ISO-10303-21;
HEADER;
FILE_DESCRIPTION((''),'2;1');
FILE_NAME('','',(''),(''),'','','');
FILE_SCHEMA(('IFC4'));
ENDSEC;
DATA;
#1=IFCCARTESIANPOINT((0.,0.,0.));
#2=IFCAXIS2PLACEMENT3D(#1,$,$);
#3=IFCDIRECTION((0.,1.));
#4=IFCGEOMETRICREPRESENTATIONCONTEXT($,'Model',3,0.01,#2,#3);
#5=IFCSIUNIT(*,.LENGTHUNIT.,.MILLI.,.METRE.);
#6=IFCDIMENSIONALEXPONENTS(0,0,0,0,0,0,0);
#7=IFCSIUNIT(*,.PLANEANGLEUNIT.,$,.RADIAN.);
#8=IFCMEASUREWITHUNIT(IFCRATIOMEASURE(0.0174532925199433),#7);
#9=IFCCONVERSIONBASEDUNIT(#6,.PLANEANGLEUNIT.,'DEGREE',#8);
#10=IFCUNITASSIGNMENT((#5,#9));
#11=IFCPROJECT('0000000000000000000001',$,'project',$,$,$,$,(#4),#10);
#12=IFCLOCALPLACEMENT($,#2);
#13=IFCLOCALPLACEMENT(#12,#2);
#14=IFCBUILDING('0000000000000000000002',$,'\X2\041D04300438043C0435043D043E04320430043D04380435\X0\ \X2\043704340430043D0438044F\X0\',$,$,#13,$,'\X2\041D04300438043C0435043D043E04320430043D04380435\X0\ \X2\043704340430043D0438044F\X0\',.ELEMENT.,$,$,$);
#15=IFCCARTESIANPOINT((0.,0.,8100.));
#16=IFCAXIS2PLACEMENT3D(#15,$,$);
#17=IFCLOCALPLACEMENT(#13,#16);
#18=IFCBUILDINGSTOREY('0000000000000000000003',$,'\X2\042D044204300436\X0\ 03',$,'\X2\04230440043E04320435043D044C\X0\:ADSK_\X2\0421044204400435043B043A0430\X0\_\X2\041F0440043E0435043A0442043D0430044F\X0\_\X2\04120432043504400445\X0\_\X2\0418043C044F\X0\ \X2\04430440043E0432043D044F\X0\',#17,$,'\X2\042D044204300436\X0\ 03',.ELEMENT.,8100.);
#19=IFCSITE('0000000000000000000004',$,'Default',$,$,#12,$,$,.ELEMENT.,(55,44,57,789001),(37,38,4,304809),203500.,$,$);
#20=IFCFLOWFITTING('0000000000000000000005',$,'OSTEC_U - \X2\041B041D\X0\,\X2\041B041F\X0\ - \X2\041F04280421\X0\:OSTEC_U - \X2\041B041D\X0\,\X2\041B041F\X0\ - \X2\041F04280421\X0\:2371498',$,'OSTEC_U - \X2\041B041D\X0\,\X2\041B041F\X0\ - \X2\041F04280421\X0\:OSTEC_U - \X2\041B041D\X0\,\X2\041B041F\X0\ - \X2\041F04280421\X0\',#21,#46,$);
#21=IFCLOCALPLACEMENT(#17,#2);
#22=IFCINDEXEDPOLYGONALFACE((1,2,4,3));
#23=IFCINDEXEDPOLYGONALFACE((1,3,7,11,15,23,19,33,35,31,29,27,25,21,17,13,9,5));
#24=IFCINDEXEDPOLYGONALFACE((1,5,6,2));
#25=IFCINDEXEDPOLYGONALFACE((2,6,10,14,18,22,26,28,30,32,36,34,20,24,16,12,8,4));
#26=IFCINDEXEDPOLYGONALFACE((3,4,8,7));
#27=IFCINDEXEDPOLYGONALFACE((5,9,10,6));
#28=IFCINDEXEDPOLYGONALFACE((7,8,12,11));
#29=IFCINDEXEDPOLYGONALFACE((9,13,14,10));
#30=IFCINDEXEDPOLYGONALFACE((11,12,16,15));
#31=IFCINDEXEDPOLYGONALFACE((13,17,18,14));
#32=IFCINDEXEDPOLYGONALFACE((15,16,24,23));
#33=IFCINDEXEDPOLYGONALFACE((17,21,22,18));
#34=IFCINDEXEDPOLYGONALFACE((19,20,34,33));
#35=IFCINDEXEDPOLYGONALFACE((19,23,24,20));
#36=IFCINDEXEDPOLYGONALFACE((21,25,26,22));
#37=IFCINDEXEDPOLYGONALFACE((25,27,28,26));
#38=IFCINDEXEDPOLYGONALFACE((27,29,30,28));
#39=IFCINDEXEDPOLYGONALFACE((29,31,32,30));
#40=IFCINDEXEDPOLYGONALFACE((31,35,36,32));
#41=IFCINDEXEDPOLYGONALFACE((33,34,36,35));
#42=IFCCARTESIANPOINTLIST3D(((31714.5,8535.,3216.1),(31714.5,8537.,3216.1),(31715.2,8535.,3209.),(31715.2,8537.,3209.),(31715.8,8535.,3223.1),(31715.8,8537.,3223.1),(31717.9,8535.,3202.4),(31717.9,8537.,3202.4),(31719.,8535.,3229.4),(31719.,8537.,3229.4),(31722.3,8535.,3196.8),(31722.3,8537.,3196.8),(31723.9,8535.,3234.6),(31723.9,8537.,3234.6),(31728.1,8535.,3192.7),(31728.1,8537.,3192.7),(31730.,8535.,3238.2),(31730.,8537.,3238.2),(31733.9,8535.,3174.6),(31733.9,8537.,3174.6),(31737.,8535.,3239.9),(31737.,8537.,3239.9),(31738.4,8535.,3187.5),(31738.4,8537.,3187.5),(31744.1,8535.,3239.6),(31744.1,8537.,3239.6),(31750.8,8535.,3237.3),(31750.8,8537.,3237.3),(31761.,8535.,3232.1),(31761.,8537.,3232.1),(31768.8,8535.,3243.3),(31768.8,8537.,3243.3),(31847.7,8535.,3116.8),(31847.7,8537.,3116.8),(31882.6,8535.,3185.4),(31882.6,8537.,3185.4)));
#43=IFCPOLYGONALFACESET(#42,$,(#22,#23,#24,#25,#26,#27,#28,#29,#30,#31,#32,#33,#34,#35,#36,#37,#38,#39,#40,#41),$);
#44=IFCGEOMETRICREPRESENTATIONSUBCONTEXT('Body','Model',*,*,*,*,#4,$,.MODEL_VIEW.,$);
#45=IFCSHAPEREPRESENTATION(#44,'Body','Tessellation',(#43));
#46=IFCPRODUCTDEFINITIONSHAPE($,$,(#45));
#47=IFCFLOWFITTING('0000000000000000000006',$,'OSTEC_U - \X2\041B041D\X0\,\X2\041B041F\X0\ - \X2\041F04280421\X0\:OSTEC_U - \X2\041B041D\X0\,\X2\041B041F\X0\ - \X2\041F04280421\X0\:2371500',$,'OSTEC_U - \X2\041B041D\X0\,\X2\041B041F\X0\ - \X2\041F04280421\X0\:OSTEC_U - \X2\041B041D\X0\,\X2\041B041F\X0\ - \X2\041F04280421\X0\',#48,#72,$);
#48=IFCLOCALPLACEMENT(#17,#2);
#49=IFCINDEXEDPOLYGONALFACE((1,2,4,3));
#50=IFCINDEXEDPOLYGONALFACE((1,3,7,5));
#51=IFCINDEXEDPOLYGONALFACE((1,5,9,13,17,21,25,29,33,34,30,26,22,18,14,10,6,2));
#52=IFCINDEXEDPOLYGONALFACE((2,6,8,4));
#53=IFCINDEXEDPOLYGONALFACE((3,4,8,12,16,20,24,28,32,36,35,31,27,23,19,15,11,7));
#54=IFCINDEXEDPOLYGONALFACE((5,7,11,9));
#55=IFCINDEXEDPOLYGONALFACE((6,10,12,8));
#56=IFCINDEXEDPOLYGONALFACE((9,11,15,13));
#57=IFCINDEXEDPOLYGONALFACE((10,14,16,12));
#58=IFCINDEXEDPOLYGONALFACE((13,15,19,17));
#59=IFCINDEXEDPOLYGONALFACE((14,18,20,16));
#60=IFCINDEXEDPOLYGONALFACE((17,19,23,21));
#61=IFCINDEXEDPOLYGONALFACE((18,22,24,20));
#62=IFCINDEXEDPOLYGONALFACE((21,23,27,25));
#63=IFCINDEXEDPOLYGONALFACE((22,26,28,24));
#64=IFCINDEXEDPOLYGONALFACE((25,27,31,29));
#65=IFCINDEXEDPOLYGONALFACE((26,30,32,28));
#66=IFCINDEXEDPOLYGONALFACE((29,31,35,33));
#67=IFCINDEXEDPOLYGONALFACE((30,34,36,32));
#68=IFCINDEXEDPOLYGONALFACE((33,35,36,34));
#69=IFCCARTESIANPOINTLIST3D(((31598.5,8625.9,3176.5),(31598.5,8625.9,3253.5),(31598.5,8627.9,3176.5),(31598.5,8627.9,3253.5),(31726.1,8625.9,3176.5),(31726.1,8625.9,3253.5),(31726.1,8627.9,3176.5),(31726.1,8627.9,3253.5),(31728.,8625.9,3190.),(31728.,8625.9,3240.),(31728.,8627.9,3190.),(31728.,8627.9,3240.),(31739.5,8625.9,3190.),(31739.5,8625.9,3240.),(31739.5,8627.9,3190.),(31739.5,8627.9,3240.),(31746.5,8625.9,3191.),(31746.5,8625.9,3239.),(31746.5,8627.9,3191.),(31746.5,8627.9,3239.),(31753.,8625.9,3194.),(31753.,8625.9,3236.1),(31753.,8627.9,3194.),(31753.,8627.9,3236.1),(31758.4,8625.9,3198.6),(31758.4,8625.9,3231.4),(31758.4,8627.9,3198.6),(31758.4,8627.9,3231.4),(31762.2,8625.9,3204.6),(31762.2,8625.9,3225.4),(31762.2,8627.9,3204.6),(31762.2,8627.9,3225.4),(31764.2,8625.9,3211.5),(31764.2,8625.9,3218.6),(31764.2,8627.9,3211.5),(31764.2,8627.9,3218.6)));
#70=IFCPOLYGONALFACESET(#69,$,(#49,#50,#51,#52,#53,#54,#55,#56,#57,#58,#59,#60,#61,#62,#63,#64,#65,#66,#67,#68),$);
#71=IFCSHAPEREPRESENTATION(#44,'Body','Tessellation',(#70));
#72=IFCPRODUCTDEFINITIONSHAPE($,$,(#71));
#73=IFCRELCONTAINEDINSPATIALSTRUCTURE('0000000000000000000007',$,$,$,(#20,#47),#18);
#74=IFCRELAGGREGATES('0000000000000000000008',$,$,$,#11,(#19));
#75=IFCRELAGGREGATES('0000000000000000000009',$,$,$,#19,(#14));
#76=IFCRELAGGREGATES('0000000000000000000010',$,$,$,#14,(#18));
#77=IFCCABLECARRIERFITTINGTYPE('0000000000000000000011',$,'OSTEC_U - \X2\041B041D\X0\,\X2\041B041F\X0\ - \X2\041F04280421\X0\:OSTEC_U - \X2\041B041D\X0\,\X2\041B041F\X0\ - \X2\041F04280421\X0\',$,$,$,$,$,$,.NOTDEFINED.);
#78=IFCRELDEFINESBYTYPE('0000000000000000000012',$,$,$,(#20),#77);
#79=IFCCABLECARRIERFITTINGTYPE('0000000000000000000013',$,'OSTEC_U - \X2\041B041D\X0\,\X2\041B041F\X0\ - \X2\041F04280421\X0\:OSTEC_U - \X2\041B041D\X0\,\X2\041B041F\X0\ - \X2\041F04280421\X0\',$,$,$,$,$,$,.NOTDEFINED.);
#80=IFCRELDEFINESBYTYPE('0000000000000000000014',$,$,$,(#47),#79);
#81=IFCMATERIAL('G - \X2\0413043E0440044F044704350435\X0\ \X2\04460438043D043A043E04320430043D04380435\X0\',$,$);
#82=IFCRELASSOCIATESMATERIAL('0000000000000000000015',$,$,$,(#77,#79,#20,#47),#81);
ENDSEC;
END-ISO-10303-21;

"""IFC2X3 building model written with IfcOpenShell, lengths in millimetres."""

from ifc_helpers import new_model, entity, si_unit, converted_unit, direction, frame, frame_2d, origin, place, context, subcontext, project, spatial, polyline, circle_curve, parameter, trimmed, segment, composite_curve, outline, extrude, source, transform, mapped, material, type_object, type_shapes, element, save


model = new_model("IFC2X3")

# Units and contexts
model_context = context("Model", 3, precision=0.01, world=origin(), true_north=direction((0.0, 1.0)))
body_context = subcontext(model_context, "Body", "Model", "MODEL_VIEW")
ifc_project = project(units=[si_unit("LENGTHUNIT", "METRE", prefix="MILLI"), converted_unit("PLANEANGLEUNIT", "DEGREE", entity("IfcRatioMeasure", 0.0174532925199433), si_unit("PLANEANGLEUNIT", "RADIAN"), dimensions=[0, 0, 0, 0, 0, 0, 0])], contexts=[model_context])

# Site, building, storey
site_placement = place(None, origin())
site = spatial("IfcSite", under=ifc_project, at=site_placement, Name="Default", CompositionType="ELEMENT", RefLatitude=(55, 44, 57, 789001), RefLongitude=(37, 38, 4, 304809), RefElevation=203500.0)
building_placement = place(site_placement, origin())
building = spatial("IfcBuilding", under=site, at=building_placement, Name="Наименование здания", LongName="Наименование здания", CompositionType="ELEMENT")
storey_placement = place(building_placement, frame((0.0, 0.0, 8100.0)))
storey = spatial("IfcBuildingStorey", under=building, at=storey_placement, Name="Этаж 03", ObjectType="Уровень:ADSK_Стрелка_Проектная_Вверх_Имя уровня", LongName="Этаж 03", CompositionType="ELEMENT", Elevation=8100.0)

# Flow fittings
ifc_material_1 = material(Name="G - Горячее цинкование")
cable_carrier_fitting_type_1 = type_object("IfcCableCarrierFittingType", Name="OSTEC_U - ЛН,ЛП - ПШС:OSTEC_U - ЛН,ЛП - ПШС", PredefinedType="NOTDEFINED", material=ifc_material_1)
shared_shape_1 = source(origin(), body_context, "Body", "SweptSolid", [
    extrude(outline(composite_curve([segment(trimmed(circle_curve(frame_2d((-41.5, 0.0), x_axis=(1.0, 0.0)), 25.0), [parameter(90.0)], [parameter(270.0)], True, "PARAMETER"), True, "CONTINUOUS"), segment(polyline([(-41.5, -25.0), (-30.0, -25.0)]), True, "CONTINUOUS"), segment(polyline([(-30.0, -25.0), (-28.1, -38.5)]), True, "CONTINUOUS"), segment(polyline([(-28.1, -38.5), (99.5, -38.5)]), True, "CONTINUOUS"), segment(polyline([(99.5, -38.5), (99.5, 38.5)]), True, "CONTINUOUS"), segment(polyline([(99.5, 38.5), (-28.1, 38.5)]), True, "CONTINUOUS"), segment(polyline([(-28.1, 38.5), (-30.0, 25.0)]), True, "CONTINUOUS"), segment(polyline([(-30.0, 25.0), (-41.5, 25.0)]), True, "CONTINUOUS")], self_intersect=False)), frame((41.5, 0.0, 0.0)), (0.0, 0.0, 1.0), 2.0),
])
type_shapes(cable_carrier_fitting_type_1, [shared_shape_1])
cable_carrier_fitting_type_2 = type_object("IfcCableCarrierFittingType", Name="OSTEC_U - ЛН,ЛП - ПШС:OSTEC_U - ЛН,ЛП - ПШС", PredefinedType="NOTDEFINED", material=ifc_material_1)
type_shapes(cable_carrier_fitting_type_2, [shared_shape_1])
flow_fitting_1_placement = place(storey_placement, frame((31739.5, 8537.0, 3215.0), z_axis=(0.0, -1.0, 0.0), x_axis=(0.891243, 0.0, -0.453526)))
element("IfcFlowFitting", 1, at=flow_fitting_1_placement, inside=storey, type_object=cable_carrier_fitting_type_1, material=ifc_material_1, Name="OSTEC_U - ЛН,ЛП - ПШС:OSTEC_U - ЛН,ЛП - ПШС:2371498", ObjectType="OSTEC_U - ЛН,ЛП - ПШС:OSTEC_U - ЛН,ЛП - ПШС", context=body_context, shape_type="MappedRepresentation", body=[
    mapped(shared_shape_1, transform((0.0, 0.0, 0.0), scale=1.0)),
])
flow_fitting_2_placement = place(storey_placement, frame((31739.5, 8625.9, 3215.0), z_axis=(0.0, 1.0, 0.0), x_axis=(-1.0, 0.0, 0.0)))
element("IfcFlowFitting", 2, at=flow_fitting_2_placement, inside=storey, type_object=cable_carrier_fitting_type_2, material=ifc_material_1, Name="OSTEC_U - ЛН,ЛП - ПШС:OSTEC_U - ЛН,ЛП - ПШС:2371500", ObjectType="OSTEC_U - ЛН,ЛП - ПШС:OSTEC_U - ЛН,ЛП - ПШС", context=body_context, shape_type="MappedRepresentation", body=[
    mapped(shared_shape_1, transform((0.0, 0.0, 0.0), scale=1.0)),
])

save(model, "model.ifc")
